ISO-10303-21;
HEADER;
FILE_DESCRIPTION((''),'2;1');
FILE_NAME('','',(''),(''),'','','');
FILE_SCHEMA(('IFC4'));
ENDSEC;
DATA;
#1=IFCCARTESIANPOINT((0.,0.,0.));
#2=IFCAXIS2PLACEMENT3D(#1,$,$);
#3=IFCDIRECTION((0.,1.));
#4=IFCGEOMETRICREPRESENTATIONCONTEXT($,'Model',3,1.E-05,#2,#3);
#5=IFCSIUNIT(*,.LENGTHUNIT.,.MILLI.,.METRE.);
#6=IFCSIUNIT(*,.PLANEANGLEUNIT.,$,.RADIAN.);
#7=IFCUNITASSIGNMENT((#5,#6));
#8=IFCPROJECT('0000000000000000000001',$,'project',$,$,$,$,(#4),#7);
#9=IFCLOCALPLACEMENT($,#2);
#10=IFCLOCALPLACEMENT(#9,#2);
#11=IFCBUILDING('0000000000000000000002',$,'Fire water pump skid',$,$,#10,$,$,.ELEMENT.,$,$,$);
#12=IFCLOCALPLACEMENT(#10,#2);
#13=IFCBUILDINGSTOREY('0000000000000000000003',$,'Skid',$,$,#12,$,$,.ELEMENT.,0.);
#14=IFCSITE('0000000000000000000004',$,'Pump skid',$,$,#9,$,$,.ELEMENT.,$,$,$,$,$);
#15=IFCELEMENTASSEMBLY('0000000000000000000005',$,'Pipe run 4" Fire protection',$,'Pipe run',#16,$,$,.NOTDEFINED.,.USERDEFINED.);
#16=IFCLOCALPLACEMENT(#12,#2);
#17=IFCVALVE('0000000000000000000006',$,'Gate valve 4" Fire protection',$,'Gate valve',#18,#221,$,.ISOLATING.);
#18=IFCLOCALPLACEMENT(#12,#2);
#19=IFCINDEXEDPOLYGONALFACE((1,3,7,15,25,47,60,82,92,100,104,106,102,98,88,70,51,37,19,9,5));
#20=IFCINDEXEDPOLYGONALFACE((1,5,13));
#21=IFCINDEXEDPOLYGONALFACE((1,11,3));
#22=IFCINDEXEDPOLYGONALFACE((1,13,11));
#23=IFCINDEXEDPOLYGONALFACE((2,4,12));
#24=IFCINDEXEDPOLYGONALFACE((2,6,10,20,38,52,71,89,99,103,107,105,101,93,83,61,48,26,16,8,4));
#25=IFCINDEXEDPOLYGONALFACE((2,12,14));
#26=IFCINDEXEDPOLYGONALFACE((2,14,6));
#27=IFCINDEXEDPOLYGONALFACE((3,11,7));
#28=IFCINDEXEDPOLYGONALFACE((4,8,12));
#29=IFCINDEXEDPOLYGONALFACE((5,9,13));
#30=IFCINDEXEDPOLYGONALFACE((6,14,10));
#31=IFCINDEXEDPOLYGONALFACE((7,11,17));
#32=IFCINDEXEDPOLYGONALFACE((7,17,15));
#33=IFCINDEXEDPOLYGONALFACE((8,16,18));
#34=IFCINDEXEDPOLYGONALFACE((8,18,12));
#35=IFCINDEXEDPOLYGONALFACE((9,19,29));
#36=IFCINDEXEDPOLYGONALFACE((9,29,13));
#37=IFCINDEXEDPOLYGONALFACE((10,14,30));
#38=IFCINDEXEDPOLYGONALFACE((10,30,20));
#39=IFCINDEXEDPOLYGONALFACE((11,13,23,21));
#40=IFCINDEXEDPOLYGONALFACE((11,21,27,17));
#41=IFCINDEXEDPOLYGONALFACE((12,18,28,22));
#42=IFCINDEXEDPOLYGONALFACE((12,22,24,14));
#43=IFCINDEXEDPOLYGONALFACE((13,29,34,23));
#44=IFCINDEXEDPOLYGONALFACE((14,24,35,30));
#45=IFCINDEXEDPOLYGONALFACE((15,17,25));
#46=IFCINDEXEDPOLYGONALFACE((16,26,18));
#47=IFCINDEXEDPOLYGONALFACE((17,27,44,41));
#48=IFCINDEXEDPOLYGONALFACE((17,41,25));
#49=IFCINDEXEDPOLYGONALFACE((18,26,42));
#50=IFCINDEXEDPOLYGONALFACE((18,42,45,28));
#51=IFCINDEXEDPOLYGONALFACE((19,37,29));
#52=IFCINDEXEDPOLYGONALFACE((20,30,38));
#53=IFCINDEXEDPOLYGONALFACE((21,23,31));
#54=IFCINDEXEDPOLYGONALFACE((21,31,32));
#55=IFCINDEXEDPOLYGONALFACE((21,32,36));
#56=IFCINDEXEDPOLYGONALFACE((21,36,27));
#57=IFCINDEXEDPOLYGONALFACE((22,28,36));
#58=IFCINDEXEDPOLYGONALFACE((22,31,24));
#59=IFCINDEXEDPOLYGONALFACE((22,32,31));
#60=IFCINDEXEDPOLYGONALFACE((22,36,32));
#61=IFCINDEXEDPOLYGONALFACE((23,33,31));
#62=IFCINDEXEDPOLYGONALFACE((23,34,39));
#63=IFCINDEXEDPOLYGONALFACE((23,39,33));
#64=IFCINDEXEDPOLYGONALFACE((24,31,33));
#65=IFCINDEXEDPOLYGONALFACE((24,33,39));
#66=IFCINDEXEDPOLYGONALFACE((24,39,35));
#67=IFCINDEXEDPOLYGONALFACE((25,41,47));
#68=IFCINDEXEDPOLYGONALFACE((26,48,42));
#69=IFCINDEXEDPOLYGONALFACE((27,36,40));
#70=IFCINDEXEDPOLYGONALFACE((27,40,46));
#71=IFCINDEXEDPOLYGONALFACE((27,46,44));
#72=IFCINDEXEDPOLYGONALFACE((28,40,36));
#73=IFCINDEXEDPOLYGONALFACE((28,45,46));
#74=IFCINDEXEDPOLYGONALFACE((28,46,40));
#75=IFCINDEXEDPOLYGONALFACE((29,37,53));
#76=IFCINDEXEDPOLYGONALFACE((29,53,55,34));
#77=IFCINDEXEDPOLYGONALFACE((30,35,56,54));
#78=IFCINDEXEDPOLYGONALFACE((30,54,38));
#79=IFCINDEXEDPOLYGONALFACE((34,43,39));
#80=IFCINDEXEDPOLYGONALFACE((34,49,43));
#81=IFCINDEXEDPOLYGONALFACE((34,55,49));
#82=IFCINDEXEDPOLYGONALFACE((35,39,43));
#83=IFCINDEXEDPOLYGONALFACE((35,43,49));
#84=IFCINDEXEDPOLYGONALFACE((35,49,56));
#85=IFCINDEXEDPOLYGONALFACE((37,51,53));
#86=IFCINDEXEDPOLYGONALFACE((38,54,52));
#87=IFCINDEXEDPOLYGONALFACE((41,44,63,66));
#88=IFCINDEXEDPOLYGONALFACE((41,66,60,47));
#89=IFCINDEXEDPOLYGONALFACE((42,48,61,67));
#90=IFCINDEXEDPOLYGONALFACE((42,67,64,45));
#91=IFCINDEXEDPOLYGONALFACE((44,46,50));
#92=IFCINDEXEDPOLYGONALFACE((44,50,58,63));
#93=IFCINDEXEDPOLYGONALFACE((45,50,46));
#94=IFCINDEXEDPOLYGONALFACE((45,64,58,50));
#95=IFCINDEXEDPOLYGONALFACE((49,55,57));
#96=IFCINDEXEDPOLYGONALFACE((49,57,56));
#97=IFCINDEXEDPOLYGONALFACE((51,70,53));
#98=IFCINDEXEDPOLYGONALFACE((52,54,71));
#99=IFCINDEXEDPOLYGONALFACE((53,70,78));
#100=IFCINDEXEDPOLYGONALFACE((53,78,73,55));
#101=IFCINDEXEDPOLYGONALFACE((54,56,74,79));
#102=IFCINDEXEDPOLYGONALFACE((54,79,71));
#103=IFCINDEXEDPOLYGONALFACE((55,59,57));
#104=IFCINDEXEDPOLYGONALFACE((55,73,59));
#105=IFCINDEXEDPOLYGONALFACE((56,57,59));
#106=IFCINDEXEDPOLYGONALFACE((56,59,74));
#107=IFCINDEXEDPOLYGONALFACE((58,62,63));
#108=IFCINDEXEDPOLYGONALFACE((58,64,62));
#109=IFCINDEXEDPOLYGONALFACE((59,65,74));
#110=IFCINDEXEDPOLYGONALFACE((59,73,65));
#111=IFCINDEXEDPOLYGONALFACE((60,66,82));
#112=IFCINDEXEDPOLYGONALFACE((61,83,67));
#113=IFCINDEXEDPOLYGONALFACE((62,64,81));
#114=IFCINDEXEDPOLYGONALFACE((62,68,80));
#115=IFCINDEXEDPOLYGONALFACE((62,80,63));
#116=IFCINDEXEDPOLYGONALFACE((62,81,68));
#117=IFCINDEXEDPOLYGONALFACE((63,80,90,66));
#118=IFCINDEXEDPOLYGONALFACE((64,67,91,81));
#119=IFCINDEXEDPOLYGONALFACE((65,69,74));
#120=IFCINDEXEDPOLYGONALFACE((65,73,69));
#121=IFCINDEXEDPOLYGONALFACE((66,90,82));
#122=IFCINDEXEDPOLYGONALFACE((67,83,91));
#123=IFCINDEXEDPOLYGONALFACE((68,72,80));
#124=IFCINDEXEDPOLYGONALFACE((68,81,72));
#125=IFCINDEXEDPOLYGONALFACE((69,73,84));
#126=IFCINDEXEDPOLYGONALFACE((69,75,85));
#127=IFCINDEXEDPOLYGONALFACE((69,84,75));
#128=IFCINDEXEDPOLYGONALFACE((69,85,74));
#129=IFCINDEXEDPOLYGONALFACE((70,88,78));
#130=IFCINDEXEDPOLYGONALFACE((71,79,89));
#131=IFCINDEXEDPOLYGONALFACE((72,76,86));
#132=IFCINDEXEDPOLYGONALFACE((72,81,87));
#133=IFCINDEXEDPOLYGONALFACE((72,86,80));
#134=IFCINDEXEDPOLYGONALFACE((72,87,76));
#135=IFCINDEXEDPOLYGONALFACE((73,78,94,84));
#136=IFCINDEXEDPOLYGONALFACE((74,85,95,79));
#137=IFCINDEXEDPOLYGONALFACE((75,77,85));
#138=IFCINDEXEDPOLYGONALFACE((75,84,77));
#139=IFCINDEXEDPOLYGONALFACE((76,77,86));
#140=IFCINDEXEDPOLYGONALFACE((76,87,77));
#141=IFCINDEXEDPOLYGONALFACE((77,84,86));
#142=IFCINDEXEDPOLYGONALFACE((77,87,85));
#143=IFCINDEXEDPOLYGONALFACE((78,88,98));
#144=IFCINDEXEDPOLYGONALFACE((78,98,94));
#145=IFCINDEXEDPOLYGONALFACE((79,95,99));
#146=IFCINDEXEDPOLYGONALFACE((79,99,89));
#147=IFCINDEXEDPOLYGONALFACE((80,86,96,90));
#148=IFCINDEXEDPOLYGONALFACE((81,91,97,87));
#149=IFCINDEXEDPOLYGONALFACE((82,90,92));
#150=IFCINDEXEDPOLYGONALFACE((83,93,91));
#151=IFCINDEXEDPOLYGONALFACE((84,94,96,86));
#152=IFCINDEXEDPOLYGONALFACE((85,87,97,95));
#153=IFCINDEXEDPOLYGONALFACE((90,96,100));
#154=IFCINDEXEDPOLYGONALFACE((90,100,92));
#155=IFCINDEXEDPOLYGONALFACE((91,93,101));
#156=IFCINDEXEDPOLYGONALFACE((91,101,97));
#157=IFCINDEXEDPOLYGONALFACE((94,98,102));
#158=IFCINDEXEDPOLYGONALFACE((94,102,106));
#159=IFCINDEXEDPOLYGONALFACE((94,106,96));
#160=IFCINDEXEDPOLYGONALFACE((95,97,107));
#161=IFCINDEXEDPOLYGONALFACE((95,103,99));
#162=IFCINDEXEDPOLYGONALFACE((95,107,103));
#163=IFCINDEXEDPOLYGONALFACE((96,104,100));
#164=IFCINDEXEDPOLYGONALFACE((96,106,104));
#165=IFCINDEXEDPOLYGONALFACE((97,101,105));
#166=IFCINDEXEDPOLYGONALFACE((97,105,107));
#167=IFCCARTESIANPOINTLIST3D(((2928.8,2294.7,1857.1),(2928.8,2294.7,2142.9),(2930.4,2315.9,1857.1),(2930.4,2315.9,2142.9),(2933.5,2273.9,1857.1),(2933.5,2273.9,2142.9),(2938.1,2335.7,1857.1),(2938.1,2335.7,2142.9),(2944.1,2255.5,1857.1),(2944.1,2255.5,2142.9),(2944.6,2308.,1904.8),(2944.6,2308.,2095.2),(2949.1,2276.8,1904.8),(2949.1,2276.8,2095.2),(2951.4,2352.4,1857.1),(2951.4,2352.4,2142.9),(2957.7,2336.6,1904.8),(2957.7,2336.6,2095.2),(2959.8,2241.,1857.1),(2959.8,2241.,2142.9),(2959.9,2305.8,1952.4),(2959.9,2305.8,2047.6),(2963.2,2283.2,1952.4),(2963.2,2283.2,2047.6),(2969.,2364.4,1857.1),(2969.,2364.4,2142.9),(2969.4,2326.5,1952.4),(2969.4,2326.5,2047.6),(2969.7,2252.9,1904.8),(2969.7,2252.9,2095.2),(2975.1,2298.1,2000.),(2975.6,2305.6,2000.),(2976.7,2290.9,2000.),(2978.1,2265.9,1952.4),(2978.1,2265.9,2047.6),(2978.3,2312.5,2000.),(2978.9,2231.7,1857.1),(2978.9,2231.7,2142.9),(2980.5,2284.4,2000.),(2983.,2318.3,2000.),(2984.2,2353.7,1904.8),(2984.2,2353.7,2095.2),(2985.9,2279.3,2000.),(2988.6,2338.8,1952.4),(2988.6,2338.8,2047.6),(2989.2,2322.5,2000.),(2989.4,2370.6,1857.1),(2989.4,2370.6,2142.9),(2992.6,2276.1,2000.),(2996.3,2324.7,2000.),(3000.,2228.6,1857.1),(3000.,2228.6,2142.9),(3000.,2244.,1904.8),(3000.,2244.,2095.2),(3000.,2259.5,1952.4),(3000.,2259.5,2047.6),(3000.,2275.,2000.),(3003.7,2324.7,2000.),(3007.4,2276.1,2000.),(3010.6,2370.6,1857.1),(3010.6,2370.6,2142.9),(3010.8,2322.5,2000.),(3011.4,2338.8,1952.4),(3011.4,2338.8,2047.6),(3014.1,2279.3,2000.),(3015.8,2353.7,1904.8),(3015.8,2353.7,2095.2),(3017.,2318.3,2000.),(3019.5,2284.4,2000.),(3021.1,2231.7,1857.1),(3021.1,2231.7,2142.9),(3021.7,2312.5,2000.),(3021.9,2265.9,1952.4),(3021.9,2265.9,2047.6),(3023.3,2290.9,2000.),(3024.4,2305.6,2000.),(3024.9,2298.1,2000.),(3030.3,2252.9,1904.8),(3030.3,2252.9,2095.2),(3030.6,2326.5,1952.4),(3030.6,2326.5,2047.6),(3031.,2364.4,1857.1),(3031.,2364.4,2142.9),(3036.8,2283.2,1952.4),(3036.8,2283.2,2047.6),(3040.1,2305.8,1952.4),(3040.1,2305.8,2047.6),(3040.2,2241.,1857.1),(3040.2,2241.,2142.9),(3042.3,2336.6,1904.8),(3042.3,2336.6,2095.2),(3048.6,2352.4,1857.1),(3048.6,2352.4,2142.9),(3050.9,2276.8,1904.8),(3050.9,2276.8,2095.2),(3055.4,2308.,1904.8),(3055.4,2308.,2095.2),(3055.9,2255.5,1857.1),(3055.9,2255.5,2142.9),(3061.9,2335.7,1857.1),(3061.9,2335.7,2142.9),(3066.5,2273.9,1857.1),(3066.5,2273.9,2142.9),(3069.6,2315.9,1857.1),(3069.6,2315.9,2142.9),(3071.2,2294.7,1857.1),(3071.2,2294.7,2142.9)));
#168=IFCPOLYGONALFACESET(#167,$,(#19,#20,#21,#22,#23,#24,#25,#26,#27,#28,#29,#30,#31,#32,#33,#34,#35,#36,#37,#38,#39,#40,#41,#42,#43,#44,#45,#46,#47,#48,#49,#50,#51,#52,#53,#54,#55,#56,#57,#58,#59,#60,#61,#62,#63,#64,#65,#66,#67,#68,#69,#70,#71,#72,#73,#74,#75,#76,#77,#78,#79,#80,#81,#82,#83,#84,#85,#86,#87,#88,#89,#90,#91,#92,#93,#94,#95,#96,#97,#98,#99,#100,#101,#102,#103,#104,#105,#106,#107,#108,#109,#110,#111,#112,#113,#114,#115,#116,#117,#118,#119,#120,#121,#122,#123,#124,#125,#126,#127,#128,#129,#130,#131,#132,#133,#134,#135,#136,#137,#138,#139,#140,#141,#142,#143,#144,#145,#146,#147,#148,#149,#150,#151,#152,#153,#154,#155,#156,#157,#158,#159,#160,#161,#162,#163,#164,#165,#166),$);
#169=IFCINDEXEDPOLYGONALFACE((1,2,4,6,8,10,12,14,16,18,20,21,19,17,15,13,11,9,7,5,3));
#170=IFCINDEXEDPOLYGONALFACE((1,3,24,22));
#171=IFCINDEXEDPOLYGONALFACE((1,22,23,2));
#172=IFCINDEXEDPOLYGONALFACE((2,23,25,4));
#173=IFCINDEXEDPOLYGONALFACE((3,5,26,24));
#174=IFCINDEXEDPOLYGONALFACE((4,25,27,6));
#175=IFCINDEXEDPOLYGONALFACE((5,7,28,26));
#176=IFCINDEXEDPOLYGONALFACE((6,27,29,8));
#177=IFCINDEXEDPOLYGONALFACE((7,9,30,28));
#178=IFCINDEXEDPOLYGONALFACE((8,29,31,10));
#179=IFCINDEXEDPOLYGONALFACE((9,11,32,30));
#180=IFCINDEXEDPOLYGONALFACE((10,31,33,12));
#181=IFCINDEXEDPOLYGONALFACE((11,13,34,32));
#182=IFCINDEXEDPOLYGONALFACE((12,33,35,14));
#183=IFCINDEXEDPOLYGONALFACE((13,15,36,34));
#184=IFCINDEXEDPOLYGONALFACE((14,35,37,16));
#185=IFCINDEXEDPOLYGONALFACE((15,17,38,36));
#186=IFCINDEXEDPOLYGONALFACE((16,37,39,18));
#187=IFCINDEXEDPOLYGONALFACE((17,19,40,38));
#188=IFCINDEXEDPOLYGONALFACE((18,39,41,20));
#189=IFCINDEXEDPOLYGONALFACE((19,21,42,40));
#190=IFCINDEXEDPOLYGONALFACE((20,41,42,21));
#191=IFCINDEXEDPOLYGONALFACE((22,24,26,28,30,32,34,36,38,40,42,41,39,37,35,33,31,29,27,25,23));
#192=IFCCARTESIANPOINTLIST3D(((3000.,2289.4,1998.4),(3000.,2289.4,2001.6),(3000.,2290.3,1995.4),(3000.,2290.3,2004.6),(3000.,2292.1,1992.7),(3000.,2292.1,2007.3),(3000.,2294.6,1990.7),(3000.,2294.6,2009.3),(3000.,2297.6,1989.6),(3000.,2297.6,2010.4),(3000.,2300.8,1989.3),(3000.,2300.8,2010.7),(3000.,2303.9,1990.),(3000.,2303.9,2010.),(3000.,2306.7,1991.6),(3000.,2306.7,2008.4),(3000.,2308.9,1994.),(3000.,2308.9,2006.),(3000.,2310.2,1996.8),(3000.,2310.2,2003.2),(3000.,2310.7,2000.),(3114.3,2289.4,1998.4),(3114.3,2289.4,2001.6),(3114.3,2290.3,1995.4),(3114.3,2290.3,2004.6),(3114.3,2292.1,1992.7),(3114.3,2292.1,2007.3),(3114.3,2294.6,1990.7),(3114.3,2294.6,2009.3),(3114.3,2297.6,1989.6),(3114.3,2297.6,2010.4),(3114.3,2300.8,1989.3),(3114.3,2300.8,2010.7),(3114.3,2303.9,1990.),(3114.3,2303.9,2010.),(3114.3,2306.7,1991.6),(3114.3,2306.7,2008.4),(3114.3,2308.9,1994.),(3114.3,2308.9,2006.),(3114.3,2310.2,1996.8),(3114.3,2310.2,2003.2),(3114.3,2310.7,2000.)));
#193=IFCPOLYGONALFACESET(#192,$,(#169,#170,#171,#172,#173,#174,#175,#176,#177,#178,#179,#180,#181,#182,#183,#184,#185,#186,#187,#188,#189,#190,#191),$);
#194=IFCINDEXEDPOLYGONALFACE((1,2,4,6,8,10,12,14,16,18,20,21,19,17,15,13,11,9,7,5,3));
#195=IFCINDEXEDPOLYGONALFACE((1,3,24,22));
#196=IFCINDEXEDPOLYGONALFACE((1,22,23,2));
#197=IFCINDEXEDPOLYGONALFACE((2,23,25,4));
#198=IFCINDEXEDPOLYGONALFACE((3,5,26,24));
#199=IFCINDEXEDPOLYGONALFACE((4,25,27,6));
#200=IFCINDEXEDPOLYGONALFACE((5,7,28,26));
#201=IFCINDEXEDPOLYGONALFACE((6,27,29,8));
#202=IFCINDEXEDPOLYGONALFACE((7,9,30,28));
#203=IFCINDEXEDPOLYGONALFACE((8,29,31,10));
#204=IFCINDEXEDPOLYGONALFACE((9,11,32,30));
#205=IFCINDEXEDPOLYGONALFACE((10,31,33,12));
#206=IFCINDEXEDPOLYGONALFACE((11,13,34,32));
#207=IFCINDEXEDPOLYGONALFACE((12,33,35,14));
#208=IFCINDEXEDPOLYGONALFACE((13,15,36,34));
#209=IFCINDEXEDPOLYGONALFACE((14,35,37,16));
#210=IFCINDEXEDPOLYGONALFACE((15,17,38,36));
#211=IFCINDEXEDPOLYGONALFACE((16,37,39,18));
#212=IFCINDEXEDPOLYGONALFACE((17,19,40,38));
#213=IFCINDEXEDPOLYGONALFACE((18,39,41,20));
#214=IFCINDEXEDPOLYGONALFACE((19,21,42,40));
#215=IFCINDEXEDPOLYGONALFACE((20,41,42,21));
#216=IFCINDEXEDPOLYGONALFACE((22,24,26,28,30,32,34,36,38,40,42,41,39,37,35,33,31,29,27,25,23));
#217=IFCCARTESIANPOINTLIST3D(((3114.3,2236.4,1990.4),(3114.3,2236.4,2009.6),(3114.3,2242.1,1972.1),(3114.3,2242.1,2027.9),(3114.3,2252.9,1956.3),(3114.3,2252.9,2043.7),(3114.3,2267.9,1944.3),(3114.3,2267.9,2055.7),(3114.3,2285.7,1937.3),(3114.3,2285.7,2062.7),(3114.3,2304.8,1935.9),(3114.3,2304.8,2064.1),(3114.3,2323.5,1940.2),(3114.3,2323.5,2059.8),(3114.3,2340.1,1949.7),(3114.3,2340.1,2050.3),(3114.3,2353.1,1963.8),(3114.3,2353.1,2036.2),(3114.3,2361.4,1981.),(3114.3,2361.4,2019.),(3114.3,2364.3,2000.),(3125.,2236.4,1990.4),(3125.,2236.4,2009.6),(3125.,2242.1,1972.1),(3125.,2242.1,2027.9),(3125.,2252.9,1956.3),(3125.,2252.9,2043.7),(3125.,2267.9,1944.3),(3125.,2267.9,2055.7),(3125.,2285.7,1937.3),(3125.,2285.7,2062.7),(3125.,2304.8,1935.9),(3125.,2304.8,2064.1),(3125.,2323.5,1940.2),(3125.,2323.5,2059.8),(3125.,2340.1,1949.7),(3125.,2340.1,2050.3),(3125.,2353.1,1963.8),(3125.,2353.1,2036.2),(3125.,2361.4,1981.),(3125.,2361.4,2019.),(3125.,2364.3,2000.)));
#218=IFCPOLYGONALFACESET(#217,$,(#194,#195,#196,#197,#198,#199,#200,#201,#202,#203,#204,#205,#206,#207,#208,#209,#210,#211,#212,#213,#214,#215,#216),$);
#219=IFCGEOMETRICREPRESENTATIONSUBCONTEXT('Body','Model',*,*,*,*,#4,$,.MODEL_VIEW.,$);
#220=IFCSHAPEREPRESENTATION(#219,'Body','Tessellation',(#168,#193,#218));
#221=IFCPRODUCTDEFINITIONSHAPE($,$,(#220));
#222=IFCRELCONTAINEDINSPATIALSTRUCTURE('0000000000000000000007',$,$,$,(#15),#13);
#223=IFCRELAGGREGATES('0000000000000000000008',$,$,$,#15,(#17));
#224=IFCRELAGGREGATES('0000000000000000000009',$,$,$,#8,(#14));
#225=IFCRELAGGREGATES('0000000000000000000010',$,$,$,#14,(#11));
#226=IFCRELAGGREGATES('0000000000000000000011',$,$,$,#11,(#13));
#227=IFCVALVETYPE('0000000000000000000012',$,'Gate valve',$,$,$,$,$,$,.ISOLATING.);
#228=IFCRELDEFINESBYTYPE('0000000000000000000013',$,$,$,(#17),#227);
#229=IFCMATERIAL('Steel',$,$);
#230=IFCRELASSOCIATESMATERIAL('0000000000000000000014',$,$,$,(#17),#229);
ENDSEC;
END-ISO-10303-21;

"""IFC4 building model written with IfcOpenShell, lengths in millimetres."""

from ifc_helpers import new_model, entity, si_unit, direction, frame, origin, origin_with_axes, origin_2d, place, context, subcontext, project, spatial, circle, extrude, material, type_object, element, aggregate, save


model = new_model("IFC4")

# Units and contexts
model_context = context("Model", 3, precision=1e-05, world=origin(), true_north=direction((0.0, 1.0)))
body_context = subcontext(model_context, "Body", "Model", "MODEL_VIEW")
ifc_project = project(units=[si_unit("LENGTHUNIT", "METRE", prefix="MILLI"), si_unit("PLANEANGLEUNIT", "RADIAN")], contexts=[model_context])

# Site, building, storey
site_placement = place(None, origin())
site = spatial("IfcSite", under=ifc_project, at=site_placement, Name="Pump skid", CompositionType="ELEMENT")
building_placement = place(site_placement, origin())
building = spatial("IfcBuilding", under=site, at=building_placement, Name="Fire water pump skid", CompositionType="ELEMENT")
storey_placement = place(building_placement, origin())
storey = spatial("IfcBuildingStorey", under=building, at=storey_placement, Name="Skid", CompositionType="ELEMENT", Elevation=0.0)

# Element assembly
ifc_material = material(Name="Steel")
assembly_1_placement = place(storey_placement, origin_with_axes())
assembly_1 = element("IfcElementAssembly", 1, at=assembly_1_placement, inside=storey, Name="Pipe run 4\" Fire protection", ObjectType="Pipe run", AssemblyPlace="NOTDEFINED", PredefinedType="USERDEFINED")

# Valve
valve_type_1 = type_object("IfcValveType", Name="Gate valve", PredefinedType="ISOLATING")
valve_1_placement = place(storey_placement, origin_with_axes())
cartesian_point_1 = entity("IfcCartesianPoint", [0.0, 0.0])
valve_1 = element("IfcValve", 2, at=valve_1_placement, type_object=valve_type_1, material=ifc_material, Name="Gate valve 4\" Fire protection", ObjectType="Gate valve", PredefinedType="ISOLATING", context=body_context, shape_type="SweptSolid", body=[
    entity("IfcRevolvedAreaSolid", entity("IfcArbitraryClosedProfileDef", "AREA", None, entity("IfcPolyline", [cartesian_point_1, entity("IfcCartesianPoint", [0.0, 71.4]), entity("IfcCartesianPoint", [142.9, 25.0]), entity("IfcCartesianPoint", [285.8, 71.4]), entity("IfcCartesianPoint", [285.8, 0.0]), cartesian_point_1])), entity("IfcAxis2Placement3D", entity("IfcCartesianPoint", [3000.0, 2300.0, 1857.1]), entity("IfcDirection", [1.0, 0.0, 0.0]), entity("IfcDirection", [0.0, 0.0, 1.0])), entity("IfcAxis1Placement", entity("IfcCartesianPoint", [0.0, 0.0, 0.0]), entity("IfcDirection", [1.0, 0.0, 0.0])), 6.283185),
    extrude(circle(Radius=10.7, at=origin_2d()), frame((3000.0, 2300.0, 2000.0), z_axis=(1.0, 0.0, 0.0), x_axis=(0.0, 1.0, 0.0)), (0.0, 0.0, 1.0), 114.3),
    extrude(circle(Radius=64.3, at=origin_2d()), frame((3114.3, 2300.0, 2000.0), z_axis=(1.0, 0.0, 0.0), x_axis=(0.0, 1.0, 0.0)), (0.0, 0.0, 1.0), 10.7),
])

aggregate(assembly_1, [valve_1])

save(model, "model.ifc")
